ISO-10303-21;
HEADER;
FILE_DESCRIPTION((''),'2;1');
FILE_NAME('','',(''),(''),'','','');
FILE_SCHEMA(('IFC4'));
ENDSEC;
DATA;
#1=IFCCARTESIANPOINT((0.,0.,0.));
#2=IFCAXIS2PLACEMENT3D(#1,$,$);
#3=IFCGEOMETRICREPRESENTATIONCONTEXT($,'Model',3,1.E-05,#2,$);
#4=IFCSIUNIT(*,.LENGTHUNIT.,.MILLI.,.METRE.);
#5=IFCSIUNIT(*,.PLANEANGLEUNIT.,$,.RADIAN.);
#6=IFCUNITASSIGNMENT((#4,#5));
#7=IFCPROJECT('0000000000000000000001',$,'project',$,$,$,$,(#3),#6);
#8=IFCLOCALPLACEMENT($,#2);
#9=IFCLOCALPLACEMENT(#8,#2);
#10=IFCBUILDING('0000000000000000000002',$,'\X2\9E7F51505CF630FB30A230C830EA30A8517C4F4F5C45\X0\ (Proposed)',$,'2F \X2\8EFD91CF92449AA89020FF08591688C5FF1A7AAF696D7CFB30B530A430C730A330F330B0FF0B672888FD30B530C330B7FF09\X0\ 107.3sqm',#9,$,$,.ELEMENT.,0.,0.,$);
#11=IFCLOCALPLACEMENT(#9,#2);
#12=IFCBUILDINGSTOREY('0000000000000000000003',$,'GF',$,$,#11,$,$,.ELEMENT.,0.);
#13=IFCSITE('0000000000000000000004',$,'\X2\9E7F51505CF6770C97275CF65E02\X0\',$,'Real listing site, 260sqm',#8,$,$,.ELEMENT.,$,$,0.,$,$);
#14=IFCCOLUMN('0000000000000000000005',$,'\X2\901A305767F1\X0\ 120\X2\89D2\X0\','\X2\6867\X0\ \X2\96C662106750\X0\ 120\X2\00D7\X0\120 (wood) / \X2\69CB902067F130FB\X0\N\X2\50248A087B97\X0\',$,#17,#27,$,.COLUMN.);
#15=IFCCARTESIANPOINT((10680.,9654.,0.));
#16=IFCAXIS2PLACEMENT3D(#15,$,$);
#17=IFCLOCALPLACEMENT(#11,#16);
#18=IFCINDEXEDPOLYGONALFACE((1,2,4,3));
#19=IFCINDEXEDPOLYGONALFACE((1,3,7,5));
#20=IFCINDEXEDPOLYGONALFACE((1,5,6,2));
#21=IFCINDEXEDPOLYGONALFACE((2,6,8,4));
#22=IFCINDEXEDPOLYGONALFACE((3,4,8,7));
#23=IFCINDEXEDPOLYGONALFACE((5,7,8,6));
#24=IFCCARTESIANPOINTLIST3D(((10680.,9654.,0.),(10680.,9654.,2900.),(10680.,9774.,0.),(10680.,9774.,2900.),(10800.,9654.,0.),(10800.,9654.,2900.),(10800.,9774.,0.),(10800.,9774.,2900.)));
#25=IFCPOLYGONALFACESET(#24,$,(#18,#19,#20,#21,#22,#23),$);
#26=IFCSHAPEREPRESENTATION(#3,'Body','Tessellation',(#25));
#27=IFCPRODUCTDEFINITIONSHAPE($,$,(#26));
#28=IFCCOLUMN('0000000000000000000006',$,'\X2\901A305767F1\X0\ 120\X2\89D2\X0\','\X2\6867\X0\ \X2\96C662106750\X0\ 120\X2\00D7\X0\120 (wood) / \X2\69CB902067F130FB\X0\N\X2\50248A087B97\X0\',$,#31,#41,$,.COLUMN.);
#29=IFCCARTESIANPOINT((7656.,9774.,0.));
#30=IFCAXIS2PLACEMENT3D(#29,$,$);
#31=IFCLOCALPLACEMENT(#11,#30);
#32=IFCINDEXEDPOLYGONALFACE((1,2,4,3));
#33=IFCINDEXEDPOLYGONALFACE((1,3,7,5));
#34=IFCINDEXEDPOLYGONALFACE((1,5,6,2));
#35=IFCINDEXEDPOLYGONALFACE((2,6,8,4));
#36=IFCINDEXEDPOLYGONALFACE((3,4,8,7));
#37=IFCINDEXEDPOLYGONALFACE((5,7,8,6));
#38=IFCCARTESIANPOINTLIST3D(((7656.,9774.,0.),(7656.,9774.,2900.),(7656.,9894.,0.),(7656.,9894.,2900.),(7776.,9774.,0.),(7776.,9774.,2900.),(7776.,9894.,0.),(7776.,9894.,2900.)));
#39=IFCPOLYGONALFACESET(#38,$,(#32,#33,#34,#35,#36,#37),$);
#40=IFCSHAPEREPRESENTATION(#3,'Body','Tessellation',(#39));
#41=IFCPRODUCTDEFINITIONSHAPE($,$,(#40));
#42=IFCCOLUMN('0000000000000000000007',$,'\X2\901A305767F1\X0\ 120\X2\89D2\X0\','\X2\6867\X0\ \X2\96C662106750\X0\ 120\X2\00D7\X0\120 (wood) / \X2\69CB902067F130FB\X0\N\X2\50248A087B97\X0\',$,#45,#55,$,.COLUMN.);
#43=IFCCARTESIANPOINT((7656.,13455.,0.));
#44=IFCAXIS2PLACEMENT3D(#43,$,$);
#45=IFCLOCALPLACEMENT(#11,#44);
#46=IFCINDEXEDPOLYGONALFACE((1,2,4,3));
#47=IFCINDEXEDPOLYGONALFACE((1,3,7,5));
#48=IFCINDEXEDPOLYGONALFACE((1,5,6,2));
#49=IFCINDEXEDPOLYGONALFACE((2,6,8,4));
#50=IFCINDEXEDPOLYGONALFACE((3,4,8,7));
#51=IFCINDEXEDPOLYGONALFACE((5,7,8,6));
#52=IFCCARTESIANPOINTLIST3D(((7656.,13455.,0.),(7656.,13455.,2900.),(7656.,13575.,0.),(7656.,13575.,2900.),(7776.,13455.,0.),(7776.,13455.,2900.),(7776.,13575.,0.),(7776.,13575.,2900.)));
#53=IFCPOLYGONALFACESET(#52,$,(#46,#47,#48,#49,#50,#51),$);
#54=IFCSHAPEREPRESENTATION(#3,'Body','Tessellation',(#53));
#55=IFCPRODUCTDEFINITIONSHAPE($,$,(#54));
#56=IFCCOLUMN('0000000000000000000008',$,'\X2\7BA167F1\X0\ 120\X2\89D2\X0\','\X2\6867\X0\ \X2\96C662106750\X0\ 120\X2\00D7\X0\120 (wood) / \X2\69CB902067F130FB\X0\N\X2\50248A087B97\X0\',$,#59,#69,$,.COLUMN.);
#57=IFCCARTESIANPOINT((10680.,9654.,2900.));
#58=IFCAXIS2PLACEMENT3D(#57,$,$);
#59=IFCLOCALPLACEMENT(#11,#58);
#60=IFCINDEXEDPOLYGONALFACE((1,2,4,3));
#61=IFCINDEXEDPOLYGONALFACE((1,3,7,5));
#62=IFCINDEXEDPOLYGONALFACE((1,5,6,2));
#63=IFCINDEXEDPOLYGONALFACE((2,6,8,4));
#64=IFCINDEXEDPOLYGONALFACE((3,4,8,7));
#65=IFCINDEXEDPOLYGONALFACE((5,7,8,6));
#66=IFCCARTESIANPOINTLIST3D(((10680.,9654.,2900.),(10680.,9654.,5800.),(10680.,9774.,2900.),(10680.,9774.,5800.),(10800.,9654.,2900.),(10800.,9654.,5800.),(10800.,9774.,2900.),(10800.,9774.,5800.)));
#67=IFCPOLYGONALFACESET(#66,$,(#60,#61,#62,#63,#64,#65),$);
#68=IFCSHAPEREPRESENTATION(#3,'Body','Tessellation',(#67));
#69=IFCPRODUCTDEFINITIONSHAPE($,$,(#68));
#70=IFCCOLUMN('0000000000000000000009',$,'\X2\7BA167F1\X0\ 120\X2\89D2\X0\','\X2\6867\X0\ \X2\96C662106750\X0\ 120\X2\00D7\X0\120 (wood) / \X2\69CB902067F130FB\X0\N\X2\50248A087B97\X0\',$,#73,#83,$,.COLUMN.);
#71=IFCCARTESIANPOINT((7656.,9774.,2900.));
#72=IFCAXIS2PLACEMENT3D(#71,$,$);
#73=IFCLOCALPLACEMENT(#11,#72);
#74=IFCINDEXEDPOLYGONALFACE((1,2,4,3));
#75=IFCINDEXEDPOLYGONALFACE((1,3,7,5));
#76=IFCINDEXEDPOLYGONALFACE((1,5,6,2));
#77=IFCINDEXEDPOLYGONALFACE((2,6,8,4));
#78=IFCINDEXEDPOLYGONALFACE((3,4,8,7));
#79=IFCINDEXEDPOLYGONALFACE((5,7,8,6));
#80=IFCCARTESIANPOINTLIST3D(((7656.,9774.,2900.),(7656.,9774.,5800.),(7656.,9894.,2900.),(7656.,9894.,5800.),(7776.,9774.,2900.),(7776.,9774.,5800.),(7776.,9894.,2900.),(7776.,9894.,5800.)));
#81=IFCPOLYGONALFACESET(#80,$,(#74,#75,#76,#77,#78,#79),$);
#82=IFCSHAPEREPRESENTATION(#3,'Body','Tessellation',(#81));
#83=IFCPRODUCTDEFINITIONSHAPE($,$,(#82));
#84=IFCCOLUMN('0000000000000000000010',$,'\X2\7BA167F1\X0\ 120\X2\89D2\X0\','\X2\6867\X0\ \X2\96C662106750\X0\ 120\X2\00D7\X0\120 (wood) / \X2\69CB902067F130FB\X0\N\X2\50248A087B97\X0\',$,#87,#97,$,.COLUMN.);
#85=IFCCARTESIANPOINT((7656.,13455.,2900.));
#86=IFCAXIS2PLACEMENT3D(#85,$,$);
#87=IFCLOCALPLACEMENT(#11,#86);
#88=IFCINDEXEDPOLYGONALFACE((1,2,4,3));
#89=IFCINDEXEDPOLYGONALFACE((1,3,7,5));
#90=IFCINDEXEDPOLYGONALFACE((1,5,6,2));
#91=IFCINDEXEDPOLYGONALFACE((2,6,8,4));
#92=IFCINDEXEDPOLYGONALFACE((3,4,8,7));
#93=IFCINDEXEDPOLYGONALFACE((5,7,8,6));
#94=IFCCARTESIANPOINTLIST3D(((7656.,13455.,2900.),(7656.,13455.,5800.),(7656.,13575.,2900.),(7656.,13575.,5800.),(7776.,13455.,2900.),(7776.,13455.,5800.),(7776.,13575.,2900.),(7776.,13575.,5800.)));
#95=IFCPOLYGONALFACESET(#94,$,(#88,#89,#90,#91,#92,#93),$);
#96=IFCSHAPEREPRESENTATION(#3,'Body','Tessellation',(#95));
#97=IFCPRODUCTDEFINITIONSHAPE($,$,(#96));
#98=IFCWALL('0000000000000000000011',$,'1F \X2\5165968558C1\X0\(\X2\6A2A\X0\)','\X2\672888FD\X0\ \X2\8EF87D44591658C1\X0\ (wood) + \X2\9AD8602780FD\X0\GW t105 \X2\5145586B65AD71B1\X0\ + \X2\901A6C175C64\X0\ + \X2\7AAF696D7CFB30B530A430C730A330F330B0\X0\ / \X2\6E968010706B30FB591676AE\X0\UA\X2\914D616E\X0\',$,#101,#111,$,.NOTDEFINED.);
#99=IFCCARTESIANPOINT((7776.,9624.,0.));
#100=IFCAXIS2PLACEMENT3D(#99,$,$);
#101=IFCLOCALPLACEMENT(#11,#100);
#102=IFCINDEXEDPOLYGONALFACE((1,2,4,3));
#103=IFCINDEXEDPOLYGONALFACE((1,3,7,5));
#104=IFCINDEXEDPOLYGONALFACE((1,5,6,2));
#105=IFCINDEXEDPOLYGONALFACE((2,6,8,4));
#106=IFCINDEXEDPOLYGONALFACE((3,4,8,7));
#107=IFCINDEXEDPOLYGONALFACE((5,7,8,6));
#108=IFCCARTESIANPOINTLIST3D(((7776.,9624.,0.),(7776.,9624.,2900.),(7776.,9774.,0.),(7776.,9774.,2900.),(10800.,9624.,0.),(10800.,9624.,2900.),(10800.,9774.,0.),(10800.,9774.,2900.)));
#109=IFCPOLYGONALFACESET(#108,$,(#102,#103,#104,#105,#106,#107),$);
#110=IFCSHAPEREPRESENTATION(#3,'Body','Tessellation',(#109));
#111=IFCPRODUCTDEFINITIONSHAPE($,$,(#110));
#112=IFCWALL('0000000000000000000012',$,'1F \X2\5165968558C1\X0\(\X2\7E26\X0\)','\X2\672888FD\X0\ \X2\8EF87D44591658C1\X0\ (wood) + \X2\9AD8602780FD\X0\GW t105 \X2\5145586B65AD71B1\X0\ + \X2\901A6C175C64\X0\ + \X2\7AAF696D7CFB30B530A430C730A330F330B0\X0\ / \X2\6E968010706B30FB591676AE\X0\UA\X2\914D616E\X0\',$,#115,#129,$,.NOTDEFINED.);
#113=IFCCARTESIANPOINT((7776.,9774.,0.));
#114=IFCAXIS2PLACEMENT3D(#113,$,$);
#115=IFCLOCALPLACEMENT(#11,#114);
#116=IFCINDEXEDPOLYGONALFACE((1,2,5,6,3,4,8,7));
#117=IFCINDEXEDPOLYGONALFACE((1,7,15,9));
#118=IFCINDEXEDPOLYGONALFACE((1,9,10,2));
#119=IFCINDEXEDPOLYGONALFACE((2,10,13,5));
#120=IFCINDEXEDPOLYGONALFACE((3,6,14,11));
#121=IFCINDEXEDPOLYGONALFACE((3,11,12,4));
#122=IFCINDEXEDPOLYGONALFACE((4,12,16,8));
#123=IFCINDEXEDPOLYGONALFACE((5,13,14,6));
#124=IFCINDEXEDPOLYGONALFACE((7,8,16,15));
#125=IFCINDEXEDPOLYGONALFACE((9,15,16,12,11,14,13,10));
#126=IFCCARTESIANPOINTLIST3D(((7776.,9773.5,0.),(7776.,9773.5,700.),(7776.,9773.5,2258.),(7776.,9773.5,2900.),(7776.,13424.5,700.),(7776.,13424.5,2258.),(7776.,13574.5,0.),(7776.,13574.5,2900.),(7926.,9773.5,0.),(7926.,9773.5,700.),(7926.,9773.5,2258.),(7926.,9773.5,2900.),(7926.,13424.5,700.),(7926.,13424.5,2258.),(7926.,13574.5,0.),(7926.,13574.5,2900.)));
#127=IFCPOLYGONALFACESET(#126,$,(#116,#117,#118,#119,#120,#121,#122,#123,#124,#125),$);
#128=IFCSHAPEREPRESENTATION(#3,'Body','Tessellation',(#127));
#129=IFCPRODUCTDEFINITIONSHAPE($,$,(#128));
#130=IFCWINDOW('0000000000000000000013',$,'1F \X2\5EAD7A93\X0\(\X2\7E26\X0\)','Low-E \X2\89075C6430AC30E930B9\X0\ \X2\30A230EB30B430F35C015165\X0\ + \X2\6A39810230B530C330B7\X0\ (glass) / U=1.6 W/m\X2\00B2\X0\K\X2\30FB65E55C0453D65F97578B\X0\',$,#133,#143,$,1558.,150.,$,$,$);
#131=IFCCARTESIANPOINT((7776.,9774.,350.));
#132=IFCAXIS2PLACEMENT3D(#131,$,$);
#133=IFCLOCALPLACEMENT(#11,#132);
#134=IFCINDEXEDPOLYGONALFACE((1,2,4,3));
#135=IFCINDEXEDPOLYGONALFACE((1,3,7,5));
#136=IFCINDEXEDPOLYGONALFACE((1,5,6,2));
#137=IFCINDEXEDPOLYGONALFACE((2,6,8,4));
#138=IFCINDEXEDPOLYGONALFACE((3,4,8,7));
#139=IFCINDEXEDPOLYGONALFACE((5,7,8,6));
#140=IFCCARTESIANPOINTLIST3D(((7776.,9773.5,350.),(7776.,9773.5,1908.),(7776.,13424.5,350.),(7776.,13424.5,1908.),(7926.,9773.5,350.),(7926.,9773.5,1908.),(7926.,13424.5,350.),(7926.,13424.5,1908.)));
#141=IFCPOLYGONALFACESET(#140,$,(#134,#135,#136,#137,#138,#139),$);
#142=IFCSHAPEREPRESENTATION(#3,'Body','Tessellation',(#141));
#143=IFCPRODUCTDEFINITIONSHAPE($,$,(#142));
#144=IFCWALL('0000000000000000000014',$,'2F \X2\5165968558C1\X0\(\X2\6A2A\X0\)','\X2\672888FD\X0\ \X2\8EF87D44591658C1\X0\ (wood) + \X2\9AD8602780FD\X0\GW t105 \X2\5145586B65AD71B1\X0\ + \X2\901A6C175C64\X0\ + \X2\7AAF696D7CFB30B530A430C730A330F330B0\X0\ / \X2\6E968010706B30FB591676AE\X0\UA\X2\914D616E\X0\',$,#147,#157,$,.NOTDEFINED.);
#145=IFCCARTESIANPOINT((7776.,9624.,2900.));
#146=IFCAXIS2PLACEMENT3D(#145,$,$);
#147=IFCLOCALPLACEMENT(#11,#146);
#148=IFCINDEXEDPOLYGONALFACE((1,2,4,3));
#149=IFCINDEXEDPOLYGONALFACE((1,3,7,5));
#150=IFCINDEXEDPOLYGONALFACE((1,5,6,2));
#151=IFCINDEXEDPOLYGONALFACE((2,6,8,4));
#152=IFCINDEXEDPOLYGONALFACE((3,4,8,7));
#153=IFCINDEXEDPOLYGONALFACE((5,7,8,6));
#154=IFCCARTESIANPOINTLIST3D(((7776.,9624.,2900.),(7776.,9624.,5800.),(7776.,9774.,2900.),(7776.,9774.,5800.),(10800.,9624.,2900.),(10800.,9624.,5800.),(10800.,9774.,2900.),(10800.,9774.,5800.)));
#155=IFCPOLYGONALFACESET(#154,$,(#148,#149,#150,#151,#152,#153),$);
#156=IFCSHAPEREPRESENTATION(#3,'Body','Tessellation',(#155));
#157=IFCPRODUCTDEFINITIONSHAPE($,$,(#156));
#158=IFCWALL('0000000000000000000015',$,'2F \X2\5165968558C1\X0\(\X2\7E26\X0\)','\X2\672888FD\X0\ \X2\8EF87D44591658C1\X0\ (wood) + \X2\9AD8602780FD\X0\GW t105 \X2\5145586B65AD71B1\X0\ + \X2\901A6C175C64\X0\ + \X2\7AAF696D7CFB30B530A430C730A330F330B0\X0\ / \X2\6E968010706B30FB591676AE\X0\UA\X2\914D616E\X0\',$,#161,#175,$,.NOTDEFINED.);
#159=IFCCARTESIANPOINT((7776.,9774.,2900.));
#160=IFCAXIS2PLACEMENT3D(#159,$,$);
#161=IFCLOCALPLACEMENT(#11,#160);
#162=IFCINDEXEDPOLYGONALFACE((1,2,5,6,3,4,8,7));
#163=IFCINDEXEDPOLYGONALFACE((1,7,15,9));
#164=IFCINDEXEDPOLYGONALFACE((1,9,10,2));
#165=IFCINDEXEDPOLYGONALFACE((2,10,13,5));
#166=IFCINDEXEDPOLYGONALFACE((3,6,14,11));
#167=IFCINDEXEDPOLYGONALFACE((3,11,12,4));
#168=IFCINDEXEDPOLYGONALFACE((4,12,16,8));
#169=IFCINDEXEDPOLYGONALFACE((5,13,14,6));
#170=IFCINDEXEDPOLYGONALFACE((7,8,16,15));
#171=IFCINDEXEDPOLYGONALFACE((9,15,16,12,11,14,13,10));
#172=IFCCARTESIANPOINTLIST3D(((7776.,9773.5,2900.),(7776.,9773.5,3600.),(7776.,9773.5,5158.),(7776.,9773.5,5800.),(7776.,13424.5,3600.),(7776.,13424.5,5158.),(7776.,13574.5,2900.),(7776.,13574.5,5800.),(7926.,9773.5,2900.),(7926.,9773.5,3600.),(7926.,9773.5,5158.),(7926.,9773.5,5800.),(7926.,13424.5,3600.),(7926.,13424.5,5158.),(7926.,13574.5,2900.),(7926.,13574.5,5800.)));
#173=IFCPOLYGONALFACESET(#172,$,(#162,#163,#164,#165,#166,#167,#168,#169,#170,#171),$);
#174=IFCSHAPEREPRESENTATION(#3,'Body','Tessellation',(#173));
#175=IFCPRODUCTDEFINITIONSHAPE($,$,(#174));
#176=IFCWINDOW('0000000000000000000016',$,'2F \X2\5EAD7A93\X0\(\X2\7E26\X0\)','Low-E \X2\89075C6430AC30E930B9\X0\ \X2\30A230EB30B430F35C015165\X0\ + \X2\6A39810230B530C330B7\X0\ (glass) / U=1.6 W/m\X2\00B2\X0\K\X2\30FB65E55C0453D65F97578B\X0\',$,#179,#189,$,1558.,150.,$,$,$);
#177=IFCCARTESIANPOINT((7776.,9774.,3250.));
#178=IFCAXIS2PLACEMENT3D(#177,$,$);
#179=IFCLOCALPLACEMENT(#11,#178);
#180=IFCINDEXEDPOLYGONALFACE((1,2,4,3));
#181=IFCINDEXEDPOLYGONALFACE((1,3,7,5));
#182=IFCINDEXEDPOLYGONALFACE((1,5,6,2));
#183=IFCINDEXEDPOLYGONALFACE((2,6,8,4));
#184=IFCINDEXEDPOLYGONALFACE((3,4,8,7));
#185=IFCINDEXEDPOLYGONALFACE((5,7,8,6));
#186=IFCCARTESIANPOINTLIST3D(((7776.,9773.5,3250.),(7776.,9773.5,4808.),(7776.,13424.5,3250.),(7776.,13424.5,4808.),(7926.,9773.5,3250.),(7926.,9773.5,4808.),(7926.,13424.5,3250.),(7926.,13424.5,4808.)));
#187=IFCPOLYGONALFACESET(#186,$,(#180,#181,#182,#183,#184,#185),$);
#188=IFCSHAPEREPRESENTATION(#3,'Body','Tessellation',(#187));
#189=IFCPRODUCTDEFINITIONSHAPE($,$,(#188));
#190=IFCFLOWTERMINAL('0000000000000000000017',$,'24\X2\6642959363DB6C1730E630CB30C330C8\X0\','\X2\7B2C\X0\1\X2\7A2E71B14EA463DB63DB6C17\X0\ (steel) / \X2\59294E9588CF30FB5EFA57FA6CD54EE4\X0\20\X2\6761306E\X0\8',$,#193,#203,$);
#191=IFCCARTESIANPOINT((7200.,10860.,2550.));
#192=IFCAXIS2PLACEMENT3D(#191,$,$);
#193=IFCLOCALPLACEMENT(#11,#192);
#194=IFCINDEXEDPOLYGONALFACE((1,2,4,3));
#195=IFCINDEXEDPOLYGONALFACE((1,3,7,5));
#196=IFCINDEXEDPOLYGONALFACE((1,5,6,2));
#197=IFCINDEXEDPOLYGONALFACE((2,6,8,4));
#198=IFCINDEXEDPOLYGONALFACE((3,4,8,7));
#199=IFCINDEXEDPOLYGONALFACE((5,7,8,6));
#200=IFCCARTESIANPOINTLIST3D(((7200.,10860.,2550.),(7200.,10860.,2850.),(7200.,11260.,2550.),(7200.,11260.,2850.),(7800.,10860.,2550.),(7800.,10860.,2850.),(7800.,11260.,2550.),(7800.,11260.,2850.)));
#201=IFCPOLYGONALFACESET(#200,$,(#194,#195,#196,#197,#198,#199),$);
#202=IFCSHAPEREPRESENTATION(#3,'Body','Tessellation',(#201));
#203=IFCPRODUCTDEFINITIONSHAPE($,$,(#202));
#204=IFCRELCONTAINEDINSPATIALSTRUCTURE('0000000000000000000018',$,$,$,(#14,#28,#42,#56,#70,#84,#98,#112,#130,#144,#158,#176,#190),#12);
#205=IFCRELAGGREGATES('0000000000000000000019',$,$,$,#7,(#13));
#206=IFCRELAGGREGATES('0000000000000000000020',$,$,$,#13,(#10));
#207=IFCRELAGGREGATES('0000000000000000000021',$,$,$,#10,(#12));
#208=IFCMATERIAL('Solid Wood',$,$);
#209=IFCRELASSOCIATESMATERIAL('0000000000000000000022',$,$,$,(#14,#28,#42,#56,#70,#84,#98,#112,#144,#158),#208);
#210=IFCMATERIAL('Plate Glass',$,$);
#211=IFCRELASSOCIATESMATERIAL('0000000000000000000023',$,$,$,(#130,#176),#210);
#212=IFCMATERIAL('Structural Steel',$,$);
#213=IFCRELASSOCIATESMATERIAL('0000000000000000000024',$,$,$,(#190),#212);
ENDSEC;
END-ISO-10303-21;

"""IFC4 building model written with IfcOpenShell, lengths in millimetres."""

from ifc_helpers import new_model, si_unit, frame, frame_2d, origin, place, context, project, spatial, rectangle, extrude, material, element, fill, save


model = new_model("IFC4")

# Units and contexts
model_context = context("Model", 3, precision=1e-05, world=origin())
ifc_project = project(units=[si_unit("LENGTHUNIT", "METRE", prefix="MILLI"), si_unit("PLANEANGLEUNIT", "RADIAN")], contexts=[model_context])

# Site, building, storey
site_placement = place(None, origin())
site = spatial("IfcSite", under=ifc_project, at=site_placement, Name="鹿児島県霧島市", ObjectType="Real listing site, 260sqm", CompositionType="ELEMENT", RefElevation=0.0)
building_placement = place(site_placement, origin())
building = spatial("IfcBuilding", under=site, at=building_placement, Name="鹿児島・アトリエ兼住居 (Proposed)", ObjectType="2F 軽量鉄骨造（外装：窯業系サイディング＋木製サッシ） 107.3sqm", CompositionType="ELEMENT", ElevationOfRefHeight=0.0, ElevationOfTerrain=0.0)
storey_placement = place(building_placement, origin())
storey = spatial("IfcBuildingStorey", under=building, at=storey_placement, Name="GF", CompositionType="ELEMENT", Elevation=0.0)

# Columns
ifc_material_1 = material(Name="Solid Wood")
column_1_placement = place(storey_placement, frame((10680.0, 9654.0, 0.0)))
element("IfcColumn", 1, at=column_1_placement, inside=storey, material=ifc_material_1, Name="通し柱 120角", Description="桧 集成材 120×120 (wood) / 構造柱・N値計算", PredefinedType="COLUMN", context=model_context, shape_type="SweptSolid", body=[
    extrude(rectangle(XDim=120.0, YDim=120.0, at=frame_2d((60.0, 60.0))), frame((10680.0, 9654.0, 0.0)), (0.0, 0.0, 1.0), 2900.0),
])
column_2_placement = place(storey_placement, frame((7656.0, 9774.0, 0.0)))
element("IfcColumn", 2, at=column_2_placement, inside=storey, material=ifc_material_1, Name="通し柱 120角", Description="桧 集成材 120×120 (wood) / 構造柱・N値計算", PredefinedType="COLUMN", context=model_context, shape_type="SweptSolid", body=[
    extrude(rectangle(XDim=120.0, YDim=120.0, at=frame_2d((60.0, 60.0))), frame((7656.0, 9774.0, 0.0)), (0.0, 0.0, 1.0), 2900.0),
])
column_3_placement = place(storey_placement, frame((7656.0, 13455.0, 0.0)))
element("IfcColumn", 3, at=column_3_placement, inside=storey, material=ifc_material_1, Name="通し柱 120角", Description="桧 集成材 120×120 (wood) / 構造柱・N値計算", PredefinedType="COLUMN", context=model_context, shape_type="SweptSolid", body=[
    extrude(rectangle(XDim=120.0, YDim=120.0, at=frame_2d((60.0, 60.0))), frame((7656.0, 13455.0, 0.0)), (0.0, 0.0, 1.0), 2900.0),
])
column_4_placement = place(storey_placement, frame((10680.0, 9654.0, 2900.0)))
element("IfcColumn", 4, at=column_4_placement, inside=storey, material=ifc_material_1, Name="管柱 120角", Description="桧 集成材 120×120 (wood) / 構造柱・N値計算", PredefinedType="COLUMN", context=model_context, shape_type="SweptSolid", body=[
    extrude(rectangle(XDim=120.0, YDim=120.0, at=frame_2d((60.0, 60.0))), frame((10680.0, 9654.0, 2900.0)), (0.0, 0.0, 1.0), 2900.0),
])
column_5_placement = place(storey_placement, frame((7656.0, 9774.0, 2900.0)))
element("IfcColumn", 5, at=column_5_placement, inside=storey, material=ifc_material_1, Name="管柱 120角", Description="桧 集成材 120×120 (wood) / 構造柱・N値計算", PredefinedType="COLUMN", context=model_context, shape_type="SweptSolid", body=[
    extrude(rectangle(XDim=120.0, YDim=120.0, at=frame_2d((60.0, 60.0))), frame((7656.0, 9774.0, 2900.0)), (0.0, 0.0, 1.0), 2900.0),
])
column_6_placement = place(storey_placement, frame((7656.0, 13455.0, 2900.0)))
element("IfcColumn", 6, at=column_6_placement, inside=storey, material=ifc_material_1, Name="管柱 120角", Description="桧 集成材 120×120 (wood) / 構造柱・N値計算", PredefinedType="COLUMN", context=model_context, shape_type="SweptSolid", body=[
    extrude(rectangle(XDim=120.0, YDim=120.0, at=frame_2d((60.0, 60.0))), frame((7656.0, 13455.0, 2900.0)), (0.0, 0.0, 1.0), 2900.0),
])

# Wall
wall_1_placement = place(storey_placement, frame((7776.0, 9624.0, 0.0)))
element("IfcWall", 7, at=wall_1_placement, inside=storey, material=ifc_material_1, Name="1F 入隅壁(横)", Description="木製 軸組外壁 (wood) + 高性能GW t105 充填断熱 + 通気層 + 窯業系サイディング / 準耐火・外皮UA配慮", PredefinedType="NOTDEFINED", context=model_context, shape_type="SweptSolid", body=[
    extrude(rectangle(XDim=3024.0, YDim=150.0, at=frame_2d((1512.0, 75.0))), frame((7776.0, 9624.0, 0.0)), (0.0, 0.0, 1.0), 2900.0),
])

# Wall, opening, window
wall_2_placement = place(storey_placement, frame((7776.0, 9774.0, 0.0)))
wall_2 = element("IfcWall", 8, at=wall_2_placement, inside=storey, material=ifc_material_1, Name="1F 入隅壁(縦)", Description="木製 軸組外壁 (wood) + 高性能GW t105 充填断熱 + 通気層 + 窯業系サイディング / 準耐火・外皮UA配慮", PredefinedType="NOTDEFINED", context=model_context, shape_type="SweptSolid", body=[
    extrude(rectangle(XDim=150.0, YDim=3801.0, at=frame_2d((75.0, 1900.0))), frame((7776.0, 9774.0, 0.0)), (0.0, 0.0, 1.0), 2900.0),
])
opening_1_placement = place(storey_placement, frame((7776.0, 9774.0, 350.0)))
opening_1 = element("IfcOpeningElement", 9, at=opening_1_placement, cuts=wall_2, PredefinedType="NOTDEFINED", context=model_context, shape_type="SweptSolid", body=[
    extrude(rectangle(XDim=150.0, YDim=3651.0, at=frame_2d((75.0, 1825.0))), frame((7776.0, 9774.0, 350.0)), (0.0, 0.0, 1.0), 1558.0),
])
ifc_material_2 = material(Name="Plate Glass")
window_1_placement = place(storey_placement, frame((7776.0, 9774.0, 350.0)))
window_1 = element("IfcWindow", 10, at=window_1_placement, inside=storey, material=ifc_material_2, Name="1F 庭窓(縦)", Description="Low-E 複層ガラス アルゴン封入 + 樹脂サッシ (glass) / U=1.6 W/m²K・日射取得型", OverallHeight=1558.0, OverallWidth=150.0, context=model_context, shape_type="SweptSolid", body=[
    extrude(rectangle(XDim=150.0, YDim=3651.0, at=frame_2d((75.0, 1825.0))), frame((7776.0, 9774.0, 350.0)), (0.0, 0.0, 1.0), 1558.0),
])
fill(opening_1, window_1)

# Wall
wall_3_placement = place(storey_placement, frame((7776.0, 9624.0, 2900.0)))
element("IfcWall", 11, at=wall_3_placement, inside=storey, material=ifc_material_1, Name="2F 入隅壁(横)", Description="木製 軸組外壁 (wood) + 高性能GW t105 充填断熱 + 通気層 + 窯業系サイディング / 準耐火・外皮UA配慮", PredefinedType="NOTDEFINED", context=model_context, shape_type="SweptSolid", body=[
    extrude(rectangle(XDim=3024.0, YDim=150.0, at=frame_2d((1512.0, 75.0))), frame((7776.0, 9624.0, 2900.0)), (0.0, 0.0, 1.0), 2900.0),
])

# Wall, opening, window
wall_4_placement = place(storey_placement, frame((7776.0, 9774.0, 2900.0)))
wall_4 = element("IfcWall", 12, at=wall_4_placement, inside=storey, material=ifc_material_1, Name="2F 入隅壁(縦)", Description="木製 軸組外壁 (wood) + 高性能GW t105 充填断熱 + 通気層 + 窯業系サイディング / 準耐火・外皮UA配慮", PredefinedType="NOTDEFINED", context=model_context, shape_type="SweptSolid", body=[
    extrude(rectangle(XDim=150.0, YDim=3801.0, at=frame_2d((75.0, 1900.0))), frame((7776.0, 9774.0, 2900.0)), (0.0, 0.0, 1.0), 2900.0),
])
opening_2_placement = place(storey_placement, frame((7776.0, 9774.0, 3250.0)))
opening_2 = element("IfcOpeningElement", 13, at=opening_2_placement, cuts=wall_4, PredefinedType="NOTDEFINED", context=model_context, shape_type="SweptSolid", body=[
    extrude(rectangle(XDim=150.0, YDim=3651.0, at=frame_2d((75.0, 1825.0))), frame((7776.0, 9774.0, 3250.0)), (0.0, 0.0, 1.0), 1558.0),
])
window_2_placement = place(storey_placement, frame((7776.0, 9774.0, 3250.0)))
window_2 = element("IfcWindow", 14, at=window_2_placement, inside=storey, material=ifc_material_2, Name="2F 庭窓(縦)", Description="Low-E 複層ガラス アルゴン封入 + 樹脂サッシ (glass) / U=1.6 W/m²K・日射取得型", OverallHeight=1558.0, OverallWidth=150.0, context=model_context, shape_type="SweptSolid", body=[
    extrude(rectangle(XDim=150.0, YDim=3651.0, at=frame_2d((75.0, 1825.0))), frame((7776.0, 9774.0, 3250.0)), (0.0, 0.0, 1.0), 1558.0),
])
fill(opening_2, window_2)

# Flow terminal
ifc_material_3 = material(Name="Structural Steel")
flow_terminal_placement = place(storey_placement, frame((7200.0, 10860.0, 2550.0)))
element("IfcFlowTerminal", 15, at=flow_terminal_placement, inside=storey, material=ifc_material_3, Name="24時間換気ユニット", Description="第1種熱交換換気 (steel) / 天井裏・建基法令20条の8", context=model_context, shape_type="SweptSolid", body=[
    extrude(rectangle(XDim=600.0, YDim=400.0, at=frame_2d((300.0, 200.0))), frame((7200.0, 10860.0, 2550.0)), (0.0, 0.0, 1.0), 300.0),
])

save(model, "model.ifc")
